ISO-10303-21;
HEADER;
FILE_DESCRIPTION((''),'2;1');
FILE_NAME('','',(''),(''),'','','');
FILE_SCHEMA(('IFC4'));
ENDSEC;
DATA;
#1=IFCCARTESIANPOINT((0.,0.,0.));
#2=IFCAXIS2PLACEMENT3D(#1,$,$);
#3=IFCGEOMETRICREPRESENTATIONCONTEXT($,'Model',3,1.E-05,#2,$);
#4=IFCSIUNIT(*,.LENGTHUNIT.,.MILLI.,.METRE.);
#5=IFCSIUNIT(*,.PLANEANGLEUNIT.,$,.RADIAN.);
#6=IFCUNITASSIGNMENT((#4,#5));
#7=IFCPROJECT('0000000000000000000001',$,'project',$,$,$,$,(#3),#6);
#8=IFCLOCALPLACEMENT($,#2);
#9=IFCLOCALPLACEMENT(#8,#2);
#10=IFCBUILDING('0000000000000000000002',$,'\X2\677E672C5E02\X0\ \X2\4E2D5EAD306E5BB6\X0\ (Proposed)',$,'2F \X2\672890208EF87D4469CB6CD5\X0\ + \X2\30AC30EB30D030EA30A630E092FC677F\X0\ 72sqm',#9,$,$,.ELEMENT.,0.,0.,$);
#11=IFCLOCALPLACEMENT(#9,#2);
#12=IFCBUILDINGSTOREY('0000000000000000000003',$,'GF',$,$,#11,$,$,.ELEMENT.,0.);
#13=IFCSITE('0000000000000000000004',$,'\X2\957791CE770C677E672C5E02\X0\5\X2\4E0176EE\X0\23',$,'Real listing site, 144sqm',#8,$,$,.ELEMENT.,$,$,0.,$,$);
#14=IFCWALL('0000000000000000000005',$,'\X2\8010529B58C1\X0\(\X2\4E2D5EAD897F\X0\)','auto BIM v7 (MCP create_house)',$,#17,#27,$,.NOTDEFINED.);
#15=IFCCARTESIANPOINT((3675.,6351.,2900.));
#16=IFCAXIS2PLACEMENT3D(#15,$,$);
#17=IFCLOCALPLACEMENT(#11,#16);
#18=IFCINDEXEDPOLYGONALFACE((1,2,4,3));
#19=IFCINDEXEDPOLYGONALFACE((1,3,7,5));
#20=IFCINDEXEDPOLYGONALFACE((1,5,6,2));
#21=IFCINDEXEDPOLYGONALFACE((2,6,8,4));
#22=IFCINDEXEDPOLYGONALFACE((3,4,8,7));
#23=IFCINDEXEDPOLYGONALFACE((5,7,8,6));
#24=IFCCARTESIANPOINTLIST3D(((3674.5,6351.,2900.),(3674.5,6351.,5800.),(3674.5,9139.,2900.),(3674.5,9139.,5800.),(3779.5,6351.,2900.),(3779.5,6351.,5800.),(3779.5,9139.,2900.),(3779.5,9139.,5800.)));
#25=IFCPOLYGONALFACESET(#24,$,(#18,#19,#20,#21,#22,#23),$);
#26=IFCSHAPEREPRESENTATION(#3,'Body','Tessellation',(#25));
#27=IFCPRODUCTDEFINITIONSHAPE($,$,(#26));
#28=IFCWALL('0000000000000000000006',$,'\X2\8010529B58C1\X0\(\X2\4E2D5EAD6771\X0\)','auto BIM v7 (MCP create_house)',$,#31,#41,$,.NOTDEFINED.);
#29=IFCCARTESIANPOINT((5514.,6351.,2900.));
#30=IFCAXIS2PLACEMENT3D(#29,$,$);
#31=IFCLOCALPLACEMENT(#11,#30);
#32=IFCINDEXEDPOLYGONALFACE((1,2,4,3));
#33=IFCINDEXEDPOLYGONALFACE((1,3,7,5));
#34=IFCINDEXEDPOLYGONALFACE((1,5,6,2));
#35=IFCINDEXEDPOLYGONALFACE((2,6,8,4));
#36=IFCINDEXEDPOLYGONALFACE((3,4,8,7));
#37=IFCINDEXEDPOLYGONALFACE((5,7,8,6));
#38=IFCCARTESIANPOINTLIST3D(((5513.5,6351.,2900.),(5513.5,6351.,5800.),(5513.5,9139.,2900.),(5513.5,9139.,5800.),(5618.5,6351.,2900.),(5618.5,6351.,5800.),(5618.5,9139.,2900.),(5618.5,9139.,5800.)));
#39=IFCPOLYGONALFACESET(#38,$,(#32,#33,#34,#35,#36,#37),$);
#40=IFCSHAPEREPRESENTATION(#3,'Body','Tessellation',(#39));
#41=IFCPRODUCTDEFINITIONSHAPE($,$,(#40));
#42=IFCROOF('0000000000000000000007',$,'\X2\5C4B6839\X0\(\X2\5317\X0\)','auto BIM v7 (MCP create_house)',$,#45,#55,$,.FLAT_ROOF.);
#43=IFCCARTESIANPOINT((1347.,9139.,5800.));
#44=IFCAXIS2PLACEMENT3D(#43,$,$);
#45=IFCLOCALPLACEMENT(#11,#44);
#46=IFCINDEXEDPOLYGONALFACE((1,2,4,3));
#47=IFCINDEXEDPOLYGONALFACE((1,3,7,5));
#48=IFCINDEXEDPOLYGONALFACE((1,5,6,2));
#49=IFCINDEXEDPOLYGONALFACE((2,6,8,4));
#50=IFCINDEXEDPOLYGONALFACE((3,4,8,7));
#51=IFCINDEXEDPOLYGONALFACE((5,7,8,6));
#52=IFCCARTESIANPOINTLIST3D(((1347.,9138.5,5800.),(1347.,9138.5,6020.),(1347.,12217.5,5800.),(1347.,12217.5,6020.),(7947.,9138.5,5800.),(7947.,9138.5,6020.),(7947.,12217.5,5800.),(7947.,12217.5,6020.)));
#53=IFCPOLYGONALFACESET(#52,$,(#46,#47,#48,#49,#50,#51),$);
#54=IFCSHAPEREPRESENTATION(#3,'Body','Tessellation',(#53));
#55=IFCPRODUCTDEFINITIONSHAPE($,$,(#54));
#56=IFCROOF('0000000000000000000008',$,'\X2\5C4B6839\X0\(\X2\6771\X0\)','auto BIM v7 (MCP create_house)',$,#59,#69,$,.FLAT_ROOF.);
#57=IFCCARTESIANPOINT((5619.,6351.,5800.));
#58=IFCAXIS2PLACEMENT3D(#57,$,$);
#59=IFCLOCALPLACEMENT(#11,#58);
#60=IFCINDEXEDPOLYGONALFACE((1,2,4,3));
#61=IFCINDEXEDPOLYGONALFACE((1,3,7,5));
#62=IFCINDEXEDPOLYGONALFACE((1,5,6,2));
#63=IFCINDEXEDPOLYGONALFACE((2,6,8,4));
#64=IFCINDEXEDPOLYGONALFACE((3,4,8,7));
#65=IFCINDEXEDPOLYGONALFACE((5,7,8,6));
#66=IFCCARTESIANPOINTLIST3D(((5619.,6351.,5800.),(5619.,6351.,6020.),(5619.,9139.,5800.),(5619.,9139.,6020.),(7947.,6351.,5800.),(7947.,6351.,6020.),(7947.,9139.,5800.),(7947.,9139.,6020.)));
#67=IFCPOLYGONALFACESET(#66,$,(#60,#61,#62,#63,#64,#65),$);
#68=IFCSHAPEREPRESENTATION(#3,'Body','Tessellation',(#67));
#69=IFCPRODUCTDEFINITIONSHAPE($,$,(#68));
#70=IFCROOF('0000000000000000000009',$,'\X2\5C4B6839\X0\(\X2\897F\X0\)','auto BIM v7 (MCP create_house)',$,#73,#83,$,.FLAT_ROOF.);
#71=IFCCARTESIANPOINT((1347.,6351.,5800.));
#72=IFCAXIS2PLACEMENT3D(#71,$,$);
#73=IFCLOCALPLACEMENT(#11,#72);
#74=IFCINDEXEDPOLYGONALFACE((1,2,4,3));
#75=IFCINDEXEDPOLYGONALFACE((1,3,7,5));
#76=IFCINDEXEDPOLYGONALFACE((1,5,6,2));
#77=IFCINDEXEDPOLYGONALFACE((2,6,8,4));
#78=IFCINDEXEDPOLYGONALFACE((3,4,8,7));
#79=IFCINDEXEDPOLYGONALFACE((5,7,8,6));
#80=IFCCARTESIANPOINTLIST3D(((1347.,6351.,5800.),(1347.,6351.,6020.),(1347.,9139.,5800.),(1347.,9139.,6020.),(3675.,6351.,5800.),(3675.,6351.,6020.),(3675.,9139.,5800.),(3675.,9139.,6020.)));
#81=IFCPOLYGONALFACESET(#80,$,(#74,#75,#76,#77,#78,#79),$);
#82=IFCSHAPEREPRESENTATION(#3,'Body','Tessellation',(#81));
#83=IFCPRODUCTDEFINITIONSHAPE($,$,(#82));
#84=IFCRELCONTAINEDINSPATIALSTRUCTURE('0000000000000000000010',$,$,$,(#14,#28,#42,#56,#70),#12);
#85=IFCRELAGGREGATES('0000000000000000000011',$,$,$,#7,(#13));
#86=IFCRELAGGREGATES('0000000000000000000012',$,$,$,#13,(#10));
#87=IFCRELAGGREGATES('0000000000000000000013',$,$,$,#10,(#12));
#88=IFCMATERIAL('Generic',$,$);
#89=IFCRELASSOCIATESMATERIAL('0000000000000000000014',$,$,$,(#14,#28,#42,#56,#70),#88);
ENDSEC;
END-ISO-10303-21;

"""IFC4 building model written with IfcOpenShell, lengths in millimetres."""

from ifc_helpers import new_model, si_unit, frame, frame_2d, origin, place, context, project, spatial, rectangle, extrude, material, element, save


model = new_model("IFC4")

# Units and contexts
model_context = context("Model", 3, precision=1e-05, world=origin())
ifc_project = project(units=[si_unit("LENGTHUNIT", "METRE", prefix="MILLI"), si_unit("PLANEANGLEUNIT", "RADIAN")], contexts=[model_context])

# Site, building, storey
site_placement = place(None, origin())
site = spatial("IfcSite", under=ifc_project, at=site_placement, Name="長野県松本市5丁目23", ObjectType="Real listing site, 144sqm", CompositionType="ELEMENT", RefElevation=0.0)
building_placement = place(site_placement, origin())
building = spatial("IfcBuilding", under=site, at=building_placement, Name="松本市 中庭の家 (Proposed)", ObjectType="2F 木造軸組構法 + ガルバリウム鋼板 72sqm", CompositionType="ELEMENT", ElevationOfRefHeight=0.0, ElevationOfTerrain=0.0)
storey_placement = place(building_placement, origin())
storey = spatial("IfcBuildingStorey", under=building, at=storey_placement, Name="GF", CompositionType="ELEMENT", Elevation=0.0)

# Shared definitions
ifc_material = material(Name="Generic")

# Walls
wall_1_placement = place(storey_placement, frame((3675.0, 6351.0, 2900.0)))
element("IfcWall", 1, at=wall_1_placement, inside=storey, material=ifc_material, Name="耐力壁(中庭西)", Description="auto BIM v7 (MCP create_house)", PredefinedType="NOTDEFINED", context=model_context, shape_type="SweptSolid", body=[
    extrude(rectangle(XDim=105.0, YDim=2788.0, at=frame_2d((52.0, 1394.0))), frame((3675.0, 6351.0, 2900.0)), (0.0, 0.0, 1.0), 2900.0),
])
wall_2_placement = place(storey_placement, frame((5514.0, 6351.0, 2900.0)))
element("IfcWall", 2, at=wall_2_placement, inside=storey, material=ifc_material, Name="耐力壁(中庭東)", Description="auto BIM v7 (MCP create_house)", PredefinedType="NOTDEFINED", context=model_context, shape_type="SweptSolid", body=[
    extrude(rectangle(XDim=105.0, YDim=2788.0, at=frame_2d((52.0, 1394.0))), frame((5514.0, 6351.0, 2900.0)), (0.0, 0.0, 1.0), 2900.0),
])

# Roofs
roof_1_placement = place(storey_placement, frame((1347.0, 9139.0, 5800.0)))
element("IfcRoof", 3, at=roof_1_placement, inside=storey, material=ifc_material, Name="屋根(北)", Description="auto BIM v7 (MCP create_house)", PredefinedType="FLAT_ROOF", context=model_context, shape_type="SweptSolid", body=[
    extrude(rectangle(XDim=6600.0, YDim=3079.0, at=frame_2d((3300.0, 1539.0))), frame((1347.0, 9139.0, 5800.0)), (0.0, 0.0, 1.0), 220.0),
])
roof_2_placement = place(storey_placement, frame((5619.0, 6351.0, 5800.0)))
element("IfcRoof", 4, at=roof_2_placement, inside=storey, material=ifc_material, Name="屋根(東)", Description="auto BIM v7 (MCP create_house)", PredefinedType="FLAT_ROOF", context=model_context, shape_type="SweptSolid", body=[
    extrude(rectangle(XDim=2328.0, YDim=2788.0, at=frame_2d((1164.0, 1394.0))), frame((5619.0, 6351.0, 5800.0)), (0.0, 0.0, 1.0), 220.0),
])
roof_3_placement = place(storey_placement, frame((1347.0, 6351.0, 5800.0)))
element("IfcRoof", 5, at=roof_3_placement, inside=storey, material=ifc_material, Name="屋根(西)", Description="auto BIM v7 (MCP create_house)", PredefinedType="FLAT_ROOF", context=model_context, shape_type="SweptSolid", body=[
    extrude(rectangle(XDim=2328.0, YDim=2788.0, at=frame_2d((1164.0, 1394.0))), frame((1347.0, 6351.0, 5800.0)), (0.0, 0.0, 1.0), 220.0),
])

save(model, "model.ifc")
